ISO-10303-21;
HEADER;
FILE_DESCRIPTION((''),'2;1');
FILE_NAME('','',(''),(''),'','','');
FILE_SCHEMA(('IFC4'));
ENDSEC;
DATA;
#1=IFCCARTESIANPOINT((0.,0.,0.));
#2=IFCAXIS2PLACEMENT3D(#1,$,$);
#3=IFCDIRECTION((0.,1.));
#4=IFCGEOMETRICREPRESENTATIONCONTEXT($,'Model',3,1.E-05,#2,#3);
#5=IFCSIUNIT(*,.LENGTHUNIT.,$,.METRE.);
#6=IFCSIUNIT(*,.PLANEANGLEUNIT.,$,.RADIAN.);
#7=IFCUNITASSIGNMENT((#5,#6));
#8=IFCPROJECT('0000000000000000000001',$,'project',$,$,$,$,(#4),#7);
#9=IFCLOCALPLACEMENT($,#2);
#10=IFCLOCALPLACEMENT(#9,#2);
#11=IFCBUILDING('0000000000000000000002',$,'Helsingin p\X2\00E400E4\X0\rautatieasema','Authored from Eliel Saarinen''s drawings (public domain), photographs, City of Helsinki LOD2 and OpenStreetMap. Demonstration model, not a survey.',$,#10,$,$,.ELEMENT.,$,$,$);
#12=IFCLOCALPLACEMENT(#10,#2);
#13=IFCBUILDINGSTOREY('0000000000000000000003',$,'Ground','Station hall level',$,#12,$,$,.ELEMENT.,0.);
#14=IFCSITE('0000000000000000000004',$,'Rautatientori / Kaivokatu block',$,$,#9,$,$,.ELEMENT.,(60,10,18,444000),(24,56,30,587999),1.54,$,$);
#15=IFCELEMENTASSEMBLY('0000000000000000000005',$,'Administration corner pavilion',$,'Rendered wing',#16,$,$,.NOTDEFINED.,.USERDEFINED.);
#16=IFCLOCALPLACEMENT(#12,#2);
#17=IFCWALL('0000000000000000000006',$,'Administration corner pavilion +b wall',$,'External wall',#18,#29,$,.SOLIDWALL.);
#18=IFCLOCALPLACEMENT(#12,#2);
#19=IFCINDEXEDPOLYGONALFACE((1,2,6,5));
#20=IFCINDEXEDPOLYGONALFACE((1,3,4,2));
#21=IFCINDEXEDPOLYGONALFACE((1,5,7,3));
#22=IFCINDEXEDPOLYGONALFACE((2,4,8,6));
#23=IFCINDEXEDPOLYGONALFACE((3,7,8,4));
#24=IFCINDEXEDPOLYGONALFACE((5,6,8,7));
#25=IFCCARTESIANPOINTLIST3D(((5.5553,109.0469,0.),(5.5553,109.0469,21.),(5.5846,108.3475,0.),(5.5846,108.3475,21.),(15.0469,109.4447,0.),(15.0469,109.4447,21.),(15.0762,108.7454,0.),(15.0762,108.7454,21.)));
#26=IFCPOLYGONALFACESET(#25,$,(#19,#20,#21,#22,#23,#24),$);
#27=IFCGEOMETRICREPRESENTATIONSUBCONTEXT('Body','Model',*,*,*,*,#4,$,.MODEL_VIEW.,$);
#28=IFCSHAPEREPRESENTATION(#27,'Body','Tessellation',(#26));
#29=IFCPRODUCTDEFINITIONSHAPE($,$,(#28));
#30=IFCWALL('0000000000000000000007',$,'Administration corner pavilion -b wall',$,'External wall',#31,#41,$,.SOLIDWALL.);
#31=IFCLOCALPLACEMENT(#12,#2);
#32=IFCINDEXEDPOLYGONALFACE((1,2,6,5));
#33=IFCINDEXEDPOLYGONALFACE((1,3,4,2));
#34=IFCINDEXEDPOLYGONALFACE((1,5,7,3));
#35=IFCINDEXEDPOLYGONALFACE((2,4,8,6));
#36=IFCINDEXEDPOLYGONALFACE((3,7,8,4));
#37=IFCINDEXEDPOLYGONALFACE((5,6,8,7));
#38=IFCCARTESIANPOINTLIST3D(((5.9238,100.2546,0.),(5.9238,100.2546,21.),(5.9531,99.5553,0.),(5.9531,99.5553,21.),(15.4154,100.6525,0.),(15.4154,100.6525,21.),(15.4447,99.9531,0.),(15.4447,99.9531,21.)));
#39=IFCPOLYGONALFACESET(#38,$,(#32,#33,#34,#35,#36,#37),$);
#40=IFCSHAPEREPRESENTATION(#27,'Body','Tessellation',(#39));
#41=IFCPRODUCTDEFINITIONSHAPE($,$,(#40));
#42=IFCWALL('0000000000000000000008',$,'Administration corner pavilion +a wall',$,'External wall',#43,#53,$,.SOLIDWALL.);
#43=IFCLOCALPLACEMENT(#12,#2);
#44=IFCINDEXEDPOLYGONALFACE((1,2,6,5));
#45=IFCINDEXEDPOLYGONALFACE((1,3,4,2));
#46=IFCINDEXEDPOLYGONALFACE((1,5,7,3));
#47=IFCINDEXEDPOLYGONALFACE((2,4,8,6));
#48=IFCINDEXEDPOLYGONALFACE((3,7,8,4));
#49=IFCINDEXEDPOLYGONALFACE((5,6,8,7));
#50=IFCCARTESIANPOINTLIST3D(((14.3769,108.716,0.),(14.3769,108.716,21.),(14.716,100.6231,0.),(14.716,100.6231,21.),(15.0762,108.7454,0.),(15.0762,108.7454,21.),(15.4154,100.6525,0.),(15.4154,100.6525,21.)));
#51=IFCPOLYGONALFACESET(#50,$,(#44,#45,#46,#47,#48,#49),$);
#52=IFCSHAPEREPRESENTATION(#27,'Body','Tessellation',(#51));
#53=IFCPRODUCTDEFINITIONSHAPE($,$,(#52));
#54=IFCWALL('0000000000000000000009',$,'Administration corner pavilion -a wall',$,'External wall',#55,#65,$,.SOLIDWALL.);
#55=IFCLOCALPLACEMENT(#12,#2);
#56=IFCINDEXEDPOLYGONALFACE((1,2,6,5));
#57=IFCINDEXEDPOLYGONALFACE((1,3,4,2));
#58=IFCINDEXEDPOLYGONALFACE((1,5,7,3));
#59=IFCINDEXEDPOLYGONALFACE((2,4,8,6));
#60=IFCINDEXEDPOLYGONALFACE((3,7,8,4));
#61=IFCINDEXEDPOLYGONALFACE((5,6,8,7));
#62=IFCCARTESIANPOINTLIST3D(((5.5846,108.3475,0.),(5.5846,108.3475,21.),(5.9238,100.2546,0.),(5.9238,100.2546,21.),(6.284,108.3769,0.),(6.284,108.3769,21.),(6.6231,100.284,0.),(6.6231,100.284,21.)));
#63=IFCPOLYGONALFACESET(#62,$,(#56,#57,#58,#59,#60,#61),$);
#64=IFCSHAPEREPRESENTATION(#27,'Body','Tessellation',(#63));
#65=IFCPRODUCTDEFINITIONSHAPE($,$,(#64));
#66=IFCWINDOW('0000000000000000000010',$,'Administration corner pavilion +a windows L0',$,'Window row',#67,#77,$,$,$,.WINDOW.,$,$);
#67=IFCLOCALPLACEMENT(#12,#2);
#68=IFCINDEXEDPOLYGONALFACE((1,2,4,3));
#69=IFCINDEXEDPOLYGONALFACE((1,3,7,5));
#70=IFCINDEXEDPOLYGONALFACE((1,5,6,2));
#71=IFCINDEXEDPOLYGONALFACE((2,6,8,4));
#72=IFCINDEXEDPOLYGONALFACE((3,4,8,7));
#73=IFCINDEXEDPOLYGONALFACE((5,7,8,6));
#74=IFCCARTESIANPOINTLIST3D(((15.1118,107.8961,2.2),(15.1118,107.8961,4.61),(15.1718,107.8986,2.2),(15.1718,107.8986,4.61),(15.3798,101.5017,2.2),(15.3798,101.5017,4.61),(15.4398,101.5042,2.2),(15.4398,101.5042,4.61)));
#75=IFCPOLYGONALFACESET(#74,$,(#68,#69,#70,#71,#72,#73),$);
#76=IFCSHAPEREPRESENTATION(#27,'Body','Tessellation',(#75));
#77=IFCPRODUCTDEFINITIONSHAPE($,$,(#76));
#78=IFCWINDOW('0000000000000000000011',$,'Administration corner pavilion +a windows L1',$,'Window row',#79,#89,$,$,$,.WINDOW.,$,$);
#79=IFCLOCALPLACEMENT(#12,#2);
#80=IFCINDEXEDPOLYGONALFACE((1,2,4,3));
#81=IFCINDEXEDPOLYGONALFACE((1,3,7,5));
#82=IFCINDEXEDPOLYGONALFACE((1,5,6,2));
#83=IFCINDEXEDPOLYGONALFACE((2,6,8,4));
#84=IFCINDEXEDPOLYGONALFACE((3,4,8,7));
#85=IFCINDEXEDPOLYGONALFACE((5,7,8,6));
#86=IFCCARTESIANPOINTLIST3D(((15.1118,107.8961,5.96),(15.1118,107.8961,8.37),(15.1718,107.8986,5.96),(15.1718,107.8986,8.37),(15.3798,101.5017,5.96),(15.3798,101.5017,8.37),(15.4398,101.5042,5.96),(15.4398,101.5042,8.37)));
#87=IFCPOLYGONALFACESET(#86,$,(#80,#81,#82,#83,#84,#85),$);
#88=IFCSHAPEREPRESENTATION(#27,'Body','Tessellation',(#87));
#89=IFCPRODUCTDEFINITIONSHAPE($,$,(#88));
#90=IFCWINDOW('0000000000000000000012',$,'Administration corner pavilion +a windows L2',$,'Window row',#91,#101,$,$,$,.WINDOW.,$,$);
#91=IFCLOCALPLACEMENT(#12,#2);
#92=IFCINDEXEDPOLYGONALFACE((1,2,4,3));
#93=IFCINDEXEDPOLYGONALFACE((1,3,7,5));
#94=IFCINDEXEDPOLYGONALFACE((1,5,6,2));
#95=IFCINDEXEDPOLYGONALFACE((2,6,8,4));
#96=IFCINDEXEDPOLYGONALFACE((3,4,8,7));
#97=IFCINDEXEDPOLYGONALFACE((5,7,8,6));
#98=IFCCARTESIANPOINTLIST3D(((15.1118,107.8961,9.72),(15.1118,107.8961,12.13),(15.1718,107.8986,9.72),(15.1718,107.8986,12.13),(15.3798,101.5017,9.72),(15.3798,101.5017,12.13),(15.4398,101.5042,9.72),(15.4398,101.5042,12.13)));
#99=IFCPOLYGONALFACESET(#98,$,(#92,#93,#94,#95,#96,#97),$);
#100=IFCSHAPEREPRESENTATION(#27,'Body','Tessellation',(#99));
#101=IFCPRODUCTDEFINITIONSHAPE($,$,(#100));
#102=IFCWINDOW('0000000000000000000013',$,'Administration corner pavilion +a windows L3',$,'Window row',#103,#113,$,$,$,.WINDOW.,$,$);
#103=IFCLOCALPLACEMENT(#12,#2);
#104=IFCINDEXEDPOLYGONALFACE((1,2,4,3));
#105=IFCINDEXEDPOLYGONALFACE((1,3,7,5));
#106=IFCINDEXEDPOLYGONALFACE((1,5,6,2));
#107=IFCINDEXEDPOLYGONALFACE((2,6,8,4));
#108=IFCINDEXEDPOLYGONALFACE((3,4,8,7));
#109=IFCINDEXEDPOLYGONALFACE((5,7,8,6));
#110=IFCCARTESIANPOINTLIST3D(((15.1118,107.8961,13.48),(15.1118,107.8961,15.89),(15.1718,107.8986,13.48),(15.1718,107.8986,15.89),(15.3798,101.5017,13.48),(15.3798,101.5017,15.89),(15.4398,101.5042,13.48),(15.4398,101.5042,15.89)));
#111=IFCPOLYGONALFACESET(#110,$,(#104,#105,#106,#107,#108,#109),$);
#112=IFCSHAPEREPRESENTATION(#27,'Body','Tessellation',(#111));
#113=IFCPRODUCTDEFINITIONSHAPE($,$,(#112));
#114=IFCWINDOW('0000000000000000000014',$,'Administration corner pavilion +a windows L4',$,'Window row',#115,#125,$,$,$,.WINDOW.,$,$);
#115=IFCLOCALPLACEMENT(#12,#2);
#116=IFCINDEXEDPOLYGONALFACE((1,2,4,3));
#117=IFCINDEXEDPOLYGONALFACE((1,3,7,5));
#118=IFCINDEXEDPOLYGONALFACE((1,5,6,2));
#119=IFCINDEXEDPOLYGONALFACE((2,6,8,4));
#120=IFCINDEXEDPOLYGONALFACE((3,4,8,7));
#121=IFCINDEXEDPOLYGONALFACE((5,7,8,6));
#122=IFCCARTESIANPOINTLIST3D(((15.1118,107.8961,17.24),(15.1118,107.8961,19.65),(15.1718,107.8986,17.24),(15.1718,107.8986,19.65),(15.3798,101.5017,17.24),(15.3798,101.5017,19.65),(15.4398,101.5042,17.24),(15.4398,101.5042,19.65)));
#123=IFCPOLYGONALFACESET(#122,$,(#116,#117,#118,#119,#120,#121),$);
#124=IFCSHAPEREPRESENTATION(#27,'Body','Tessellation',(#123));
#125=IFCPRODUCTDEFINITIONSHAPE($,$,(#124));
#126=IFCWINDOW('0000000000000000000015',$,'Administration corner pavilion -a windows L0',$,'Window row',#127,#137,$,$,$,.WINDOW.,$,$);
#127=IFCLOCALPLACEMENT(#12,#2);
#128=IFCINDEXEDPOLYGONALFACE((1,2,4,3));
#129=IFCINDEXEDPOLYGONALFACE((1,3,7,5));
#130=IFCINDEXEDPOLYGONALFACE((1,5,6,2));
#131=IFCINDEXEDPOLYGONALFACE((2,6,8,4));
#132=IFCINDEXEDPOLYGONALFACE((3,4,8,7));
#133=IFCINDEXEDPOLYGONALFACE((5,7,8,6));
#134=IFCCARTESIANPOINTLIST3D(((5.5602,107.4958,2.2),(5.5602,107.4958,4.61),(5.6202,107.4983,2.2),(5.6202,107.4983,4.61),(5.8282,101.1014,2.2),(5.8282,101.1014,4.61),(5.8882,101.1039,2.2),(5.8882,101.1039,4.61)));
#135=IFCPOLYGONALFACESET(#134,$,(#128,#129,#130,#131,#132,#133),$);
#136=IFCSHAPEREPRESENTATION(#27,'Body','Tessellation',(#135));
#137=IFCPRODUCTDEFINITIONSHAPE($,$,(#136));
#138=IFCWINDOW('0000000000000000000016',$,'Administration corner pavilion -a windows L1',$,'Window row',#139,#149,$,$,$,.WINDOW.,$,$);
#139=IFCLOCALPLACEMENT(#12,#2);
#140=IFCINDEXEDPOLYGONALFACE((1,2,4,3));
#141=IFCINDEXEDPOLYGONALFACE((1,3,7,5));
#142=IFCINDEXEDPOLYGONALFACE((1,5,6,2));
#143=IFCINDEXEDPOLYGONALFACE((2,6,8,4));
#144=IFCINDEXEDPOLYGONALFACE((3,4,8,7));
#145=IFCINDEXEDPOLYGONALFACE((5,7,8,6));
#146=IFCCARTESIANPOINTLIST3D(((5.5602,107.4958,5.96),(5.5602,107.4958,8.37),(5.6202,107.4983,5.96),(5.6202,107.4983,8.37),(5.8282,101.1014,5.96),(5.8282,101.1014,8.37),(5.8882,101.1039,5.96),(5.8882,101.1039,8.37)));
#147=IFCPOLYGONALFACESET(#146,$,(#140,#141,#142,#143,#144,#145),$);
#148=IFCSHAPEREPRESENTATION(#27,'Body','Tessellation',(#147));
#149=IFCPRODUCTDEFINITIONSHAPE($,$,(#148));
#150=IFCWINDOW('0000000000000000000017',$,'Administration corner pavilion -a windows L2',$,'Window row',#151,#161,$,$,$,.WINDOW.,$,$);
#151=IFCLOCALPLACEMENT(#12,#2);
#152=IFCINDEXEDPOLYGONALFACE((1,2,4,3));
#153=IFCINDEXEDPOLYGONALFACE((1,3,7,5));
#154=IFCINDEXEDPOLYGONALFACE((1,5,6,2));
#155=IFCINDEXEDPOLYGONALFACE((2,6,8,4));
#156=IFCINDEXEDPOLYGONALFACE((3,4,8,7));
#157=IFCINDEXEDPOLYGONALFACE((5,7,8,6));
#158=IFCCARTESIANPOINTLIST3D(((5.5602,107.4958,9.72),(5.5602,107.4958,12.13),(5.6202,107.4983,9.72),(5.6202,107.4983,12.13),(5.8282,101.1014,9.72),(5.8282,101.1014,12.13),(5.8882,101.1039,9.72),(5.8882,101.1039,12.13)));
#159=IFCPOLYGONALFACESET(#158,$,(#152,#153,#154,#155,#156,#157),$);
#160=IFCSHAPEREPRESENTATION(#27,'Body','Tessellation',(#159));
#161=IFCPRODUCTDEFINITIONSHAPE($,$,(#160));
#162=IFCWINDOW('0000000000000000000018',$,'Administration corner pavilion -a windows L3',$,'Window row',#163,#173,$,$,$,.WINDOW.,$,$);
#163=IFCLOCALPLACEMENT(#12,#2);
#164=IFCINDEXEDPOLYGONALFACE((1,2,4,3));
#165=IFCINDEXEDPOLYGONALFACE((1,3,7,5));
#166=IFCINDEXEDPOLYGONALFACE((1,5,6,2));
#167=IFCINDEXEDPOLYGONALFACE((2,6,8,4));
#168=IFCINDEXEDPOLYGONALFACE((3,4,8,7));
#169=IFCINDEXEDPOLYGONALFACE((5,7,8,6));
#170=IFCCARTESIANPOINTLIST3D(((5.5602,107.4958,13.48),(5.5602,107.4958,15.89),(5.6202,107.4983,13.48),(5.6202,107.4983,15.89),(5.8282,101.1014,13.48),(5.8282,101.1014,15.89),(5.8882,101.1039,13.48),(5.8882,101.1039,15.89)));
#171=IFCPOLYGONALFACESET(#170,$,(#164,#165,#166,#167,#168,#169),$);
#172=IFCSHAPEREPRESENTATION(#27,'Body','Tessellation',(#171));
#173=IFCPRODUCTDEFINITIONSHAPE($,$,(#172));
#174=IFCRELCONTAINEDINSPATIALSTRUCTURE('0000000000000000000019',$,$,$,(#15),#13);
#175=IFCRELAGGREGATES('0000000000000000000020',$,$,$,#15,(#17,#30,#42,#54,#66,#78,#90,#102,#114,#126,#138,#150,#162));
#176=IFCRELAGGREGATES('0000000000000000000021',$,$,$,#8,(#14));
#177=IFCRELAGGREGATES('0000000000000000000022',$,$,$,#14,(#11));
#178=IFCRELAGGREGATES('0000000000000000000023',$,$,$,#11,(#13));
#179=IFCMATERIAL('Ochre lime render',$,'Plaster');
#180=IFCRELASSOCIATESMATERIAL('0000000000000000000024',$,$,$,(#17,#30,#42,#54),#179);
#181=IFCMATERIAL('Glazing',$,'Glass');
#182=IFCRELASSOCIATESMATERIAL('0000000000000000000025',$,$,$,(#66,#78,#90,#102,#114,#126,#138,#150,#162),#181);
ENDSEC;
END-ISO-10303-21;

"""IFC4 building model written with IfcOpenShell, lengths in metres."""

from ifc_helpers import new_model, si_unit, direction, frame, frame_2d, origin, place, context, subcontext, project, spatial, rectangle, extrude, material, element, aggregate, save


model = new_model("IFC4")

# Units and contexts
model_context = context("Model", 3, precision=1e-05, world=origin(), true_north=direction((0.0, 1.0)))
body_context = subcontext(model_context, "Body", "Model", "MODEL_VIEW")
ifc_project = project(units=[si_unit("LENGTHUNIT", "METRE"), si_unit("PLANEANGLEUNIT", "RADIAN")], contexts=[model_context])

# Site, building, storey
site_placement = place(None, origin())
site = spatial("IfcSite", under=ifc_project, at=site_placement, Name="Rautatientori / Kaivokatu block", CompositionType="ELEMENT", RefLatitude=(60, 10, 18, 444000), RefLongitude=(24, 56, 30, 587999), RefElevation=1.54)
building_placement = place(site_placement, origin())
building = spatial("IfcBuilding", under=site, at=building_placement, Name="Helsingin päärautatieasema", Description="Authored from Eliel Saarinen's drawings (public domain), photographs, City of Helsinki LOD2 and OpenStreetMap. Demonstration model, not a survey.", CompositionType="ELEMENT")
storey_placement = place(building_placement, origin())
storey = spatial("IfcBuildingStorey", under=building, at=storey_placement, Name="Ground", Description="Station hall level", CompositionType="ELEMENT", Elevation=0.0)

# Element assembly
assembly_1_placement = place(building_placement, origin())
assembly_1 = element("IfcElementAssembly", 1, at=assembly_1_placement, inside=storey, Name="Administration corner pavilion", ObjectType="Rendered wing", AssemblyPlace="NOTDEFINED", PredefinedType="USERDEFINED")

# Shared definitions
ifc_material_1 = material(Name="Glazing", Category="Glass")

# Walls
ifc_material_2 = material(Name="Ochre lime render", Category="Plaster")
wall_1_placement = place(building_placement, origin())
wall_1 = element("IfcWall", 2, at=wall_1_placement, material=ifc_material_2, Name="Administration corner pavilion +b wall", ObjectType="External wall", PredefinedType="SOLIDWALL", context=body_context, shape_type="SweptSolid", body=[
    extrude(rectangle(XDim=9.5, YDim=0.7, at=frame_2d((0.0, 0.0), x_axis=(-0.999123, -0.041876))), frame((10.3157, 108.8961, 0.0)), (0.0, 0.0, 1.0), 21.0),
])
wall_2_placement = place(building_placement, origin())
wall_2 = element("IfcWall", 3, at=wall_2_placement, material=ifc_material_2, Name="Administration corner pavilion -b wall", ObjectType="External wall", PredefinedType="SOLIDWALL", context=body_context, shape_type="SweptSolid", body=[
    extrude(rectangle(XDim=9.5, YDim=0.7, at=frame_2d((0.0, 0.0), x_axis=(0.999123, 0.041876))), frame((10.6843, 100.1039, 0.0)), (0.0, 0.0, 1.0), 21.0),
])
wall_3_placement = place(building_placement, origin())
wall_3 = element("IfcWall", 4, at=wall_3_placement, material=ifc_material_2, Name="Administration corner pavilion +a wall", ObjectType="External wall", PredefinedType="SOLIDWALL", context=body_context, shape_type="SweptSolid", body=[
    extrude(rectangle(XDim=8.1, YDim=0.7, at=frame_2d((0.0, 0.0), x_axis=(-0.041876, 0.999123))), frame((14.8961, 104.6843, 0.0)), (0.0, 0.0, 1.0), 21.0),
])
wall_4_placement = place(building_placement, origin())
wall_4 = element("IfcWall", 5, at=wall_4_placement, material=ifc_material_2, Name="Administration corner pavilion -a wall", ObjectType="External wall", PredefinedType="SOLIDWALL", context=body_context, shape_type="SweptSolid", body=[
    extrude(rectangle(XDim=8.1, YDim=0.7, at=frame_2d((0.0, 0.0), x_axis=(0.041876, -0.999123))), frame((6.1039, 104.3157, 0.0)), (0.0, 0.0, 1.0), 21.0),
])

# Windows
window_1_placement = place(building_placement, origin())
window_1 = element("IfcWindow", 6, at=window_1_placement, material=ifc_material_1, Name="Administration corner pavilion +a windows L0", ObjectType="Window row", PredefinedType="WINDOW", context=body_context, shape_type="SweptSolid", body=[
    extrude(rectangle(XDim=6.4, YDim=0.06, at=frame_2d((0.0, 0.0), x_axis=(-0.041876, 0.999123))), frame((15.2758, 104.7002, 2.2)), (0.0, 0.0, 1.0), 2.41),
])
window_2_placement = place(building_placement, origin())
window_2 = element("IfcWindow", 7, at=window_2_placement, material=ifc_material_1, Name="Administration corner pavilion +a windows L1", ObjectType="Window row", PredefinedType="WINDOW", context=body_context, shape_type="SweptSolid", body=[
    extrude(rectangle(XDim=6.4, YDim=0.06, at=frame_2d((0.0, 0.0), x_axis=(-0.041876, 0.999123))), frame((15.2758, 104.7002, 5.96)), (0.0, 0.0, 1.0), 2.41),
])
window_3_placement = place(building_placement, origin())
window_3 = element("IfcWindow", 8, at=window_3_placement, material=ifc_material_1, Name="Administration corner pavilion +a windows L2", ObjectType="Window row", PredefinedType="WINDOW", context=body_context, shape_type="SweptSolid", body=[
    extrude(rectangle(XDim=6.4, YDim=0.06, at=frame_2d((0.0, 0.0), x_axis=(-0.041876, 0.999123))), frame((15.2758, 104.7002, 9.72)), (0.0, 0.0, 1.0), 2.41),
])
window_4_placement = place(building_placement, origin())
window_4 = element("IfcWindow", 9, at=window_4_placement, material=ifc_material_1, Name="Administration corner pavilion +a windows L3", ObjectType="Window row", PredefinedType="WINDOW", context=body_context, shape_type="SweptSolid", body=[
    extrude(rectangle(XDim=6.4, YDim=0.06, at=frame_2d((0.0, 0.0), x_axis=(-0.041876, 0.999123))), frame((15.2758, 104.7002, 13.48)), (0.0, 0.0, 1.0), 2.41),
])
window_5_placement = place(building_placement, origin())
window_5 = element("IfcWindow", 10, at=window_5_placement, material=ifc_material_1, Name="Administration corner pavilion +a windows L4", ObjectType="Window row", PredefinedType="WINDOW", context=body_context, shape_type="SweptSolid", body=[
    extrude(rectangle(XDim=6.4, YDim=0.06, at=frame_2d((0.0, 0.0), x_axis=(-0.041876, 0.999123))), frame((15.2758, 104.7002, 17.24)), (0.0, 0.0, 1.0), 2.41),
])
window_6_placement = place(building_placement, origin())
window_6 = element("IfcWindow", 11, at=window_6_placement, material=ifc_material_1, Name="Administration corner pavilion -a windows L0", ObjectType="Window row", PredefinedType="WINDOW", context=body_context, shape_type="SweptSolid", body=[
    extrude(rectangle(XDim=6.4, YDim=0.06, at=frame_2d((0.0, 0.0), x_axis=(0.041876, -0.999123))), frame((5.7242, 104.2998, 2.2)), (0.0, 0.0, 1.0), 2.41),
])
window_7_placement = place(building_placement, origin())
window_7 = element("IfcWindow", 12, at=window_7_placement, material=ifc_material_1, Name="Administration corner pavilion -a windows L1", ObjectType="Window row", PredefinedType="WINDOW", context=body_context, shape_type="SweptSolid", body=[
    extrude(rectangle(XDim=6.4, YDim=0.06, at=frame_2d((0.0, 0.0), x_axis=(0.041876, -0.999123))), frame((5.7242, 104.2998, 5.96)), (0.0, 0.0, 1.0), 2.41),
])
window_8_placement = place(building_placement, origin())
window_8 = element("IfcWindow", 13, at=window_8_placement, material=ifc_material_1, Name="Administration corner pavilion -a windows L2", ObjectType="Window row", PredefinedType="WINDOW", context=body_context, shape_type="SweptSolid", body=[
    extrude(rectangle(XDim=6.4, YDim=0.06, at=frame_2d((0.0, 0.0), x_axis=(0.041876, -0.999123))), frame((5.7242, 104.2998, 9.72)), (0.0, 0.0, 1.0), 2.41),
])
window_9_placement = place(building_placement, origin())
window_9 = element("IfcWindow", 14, at=window_9_placement, material=ifc_material_1, Name="Administration corner pavilion -a windows L3", ObjectType="Window row", PredefinedType="WINDOW", context=body_context, shape_type="SweptSolid", body=[
    extrude(rectangle(XDim=6.4, YDim=0.06, at=frame_2d((0.0, 0.0), x_axis=(0.041876, -0.999123))), frame((5.7242, 104.2998, 13.48)), (0.0, 0.0, 1.0), 2.41),
])
aggregate(assembly_1, [wall_1, wall_2, wall_3, wall_4, window_1, window_2, window_3, window_4, window_5, window_6, window_7, window_8, window_9])

save(model, "model.ifc")
